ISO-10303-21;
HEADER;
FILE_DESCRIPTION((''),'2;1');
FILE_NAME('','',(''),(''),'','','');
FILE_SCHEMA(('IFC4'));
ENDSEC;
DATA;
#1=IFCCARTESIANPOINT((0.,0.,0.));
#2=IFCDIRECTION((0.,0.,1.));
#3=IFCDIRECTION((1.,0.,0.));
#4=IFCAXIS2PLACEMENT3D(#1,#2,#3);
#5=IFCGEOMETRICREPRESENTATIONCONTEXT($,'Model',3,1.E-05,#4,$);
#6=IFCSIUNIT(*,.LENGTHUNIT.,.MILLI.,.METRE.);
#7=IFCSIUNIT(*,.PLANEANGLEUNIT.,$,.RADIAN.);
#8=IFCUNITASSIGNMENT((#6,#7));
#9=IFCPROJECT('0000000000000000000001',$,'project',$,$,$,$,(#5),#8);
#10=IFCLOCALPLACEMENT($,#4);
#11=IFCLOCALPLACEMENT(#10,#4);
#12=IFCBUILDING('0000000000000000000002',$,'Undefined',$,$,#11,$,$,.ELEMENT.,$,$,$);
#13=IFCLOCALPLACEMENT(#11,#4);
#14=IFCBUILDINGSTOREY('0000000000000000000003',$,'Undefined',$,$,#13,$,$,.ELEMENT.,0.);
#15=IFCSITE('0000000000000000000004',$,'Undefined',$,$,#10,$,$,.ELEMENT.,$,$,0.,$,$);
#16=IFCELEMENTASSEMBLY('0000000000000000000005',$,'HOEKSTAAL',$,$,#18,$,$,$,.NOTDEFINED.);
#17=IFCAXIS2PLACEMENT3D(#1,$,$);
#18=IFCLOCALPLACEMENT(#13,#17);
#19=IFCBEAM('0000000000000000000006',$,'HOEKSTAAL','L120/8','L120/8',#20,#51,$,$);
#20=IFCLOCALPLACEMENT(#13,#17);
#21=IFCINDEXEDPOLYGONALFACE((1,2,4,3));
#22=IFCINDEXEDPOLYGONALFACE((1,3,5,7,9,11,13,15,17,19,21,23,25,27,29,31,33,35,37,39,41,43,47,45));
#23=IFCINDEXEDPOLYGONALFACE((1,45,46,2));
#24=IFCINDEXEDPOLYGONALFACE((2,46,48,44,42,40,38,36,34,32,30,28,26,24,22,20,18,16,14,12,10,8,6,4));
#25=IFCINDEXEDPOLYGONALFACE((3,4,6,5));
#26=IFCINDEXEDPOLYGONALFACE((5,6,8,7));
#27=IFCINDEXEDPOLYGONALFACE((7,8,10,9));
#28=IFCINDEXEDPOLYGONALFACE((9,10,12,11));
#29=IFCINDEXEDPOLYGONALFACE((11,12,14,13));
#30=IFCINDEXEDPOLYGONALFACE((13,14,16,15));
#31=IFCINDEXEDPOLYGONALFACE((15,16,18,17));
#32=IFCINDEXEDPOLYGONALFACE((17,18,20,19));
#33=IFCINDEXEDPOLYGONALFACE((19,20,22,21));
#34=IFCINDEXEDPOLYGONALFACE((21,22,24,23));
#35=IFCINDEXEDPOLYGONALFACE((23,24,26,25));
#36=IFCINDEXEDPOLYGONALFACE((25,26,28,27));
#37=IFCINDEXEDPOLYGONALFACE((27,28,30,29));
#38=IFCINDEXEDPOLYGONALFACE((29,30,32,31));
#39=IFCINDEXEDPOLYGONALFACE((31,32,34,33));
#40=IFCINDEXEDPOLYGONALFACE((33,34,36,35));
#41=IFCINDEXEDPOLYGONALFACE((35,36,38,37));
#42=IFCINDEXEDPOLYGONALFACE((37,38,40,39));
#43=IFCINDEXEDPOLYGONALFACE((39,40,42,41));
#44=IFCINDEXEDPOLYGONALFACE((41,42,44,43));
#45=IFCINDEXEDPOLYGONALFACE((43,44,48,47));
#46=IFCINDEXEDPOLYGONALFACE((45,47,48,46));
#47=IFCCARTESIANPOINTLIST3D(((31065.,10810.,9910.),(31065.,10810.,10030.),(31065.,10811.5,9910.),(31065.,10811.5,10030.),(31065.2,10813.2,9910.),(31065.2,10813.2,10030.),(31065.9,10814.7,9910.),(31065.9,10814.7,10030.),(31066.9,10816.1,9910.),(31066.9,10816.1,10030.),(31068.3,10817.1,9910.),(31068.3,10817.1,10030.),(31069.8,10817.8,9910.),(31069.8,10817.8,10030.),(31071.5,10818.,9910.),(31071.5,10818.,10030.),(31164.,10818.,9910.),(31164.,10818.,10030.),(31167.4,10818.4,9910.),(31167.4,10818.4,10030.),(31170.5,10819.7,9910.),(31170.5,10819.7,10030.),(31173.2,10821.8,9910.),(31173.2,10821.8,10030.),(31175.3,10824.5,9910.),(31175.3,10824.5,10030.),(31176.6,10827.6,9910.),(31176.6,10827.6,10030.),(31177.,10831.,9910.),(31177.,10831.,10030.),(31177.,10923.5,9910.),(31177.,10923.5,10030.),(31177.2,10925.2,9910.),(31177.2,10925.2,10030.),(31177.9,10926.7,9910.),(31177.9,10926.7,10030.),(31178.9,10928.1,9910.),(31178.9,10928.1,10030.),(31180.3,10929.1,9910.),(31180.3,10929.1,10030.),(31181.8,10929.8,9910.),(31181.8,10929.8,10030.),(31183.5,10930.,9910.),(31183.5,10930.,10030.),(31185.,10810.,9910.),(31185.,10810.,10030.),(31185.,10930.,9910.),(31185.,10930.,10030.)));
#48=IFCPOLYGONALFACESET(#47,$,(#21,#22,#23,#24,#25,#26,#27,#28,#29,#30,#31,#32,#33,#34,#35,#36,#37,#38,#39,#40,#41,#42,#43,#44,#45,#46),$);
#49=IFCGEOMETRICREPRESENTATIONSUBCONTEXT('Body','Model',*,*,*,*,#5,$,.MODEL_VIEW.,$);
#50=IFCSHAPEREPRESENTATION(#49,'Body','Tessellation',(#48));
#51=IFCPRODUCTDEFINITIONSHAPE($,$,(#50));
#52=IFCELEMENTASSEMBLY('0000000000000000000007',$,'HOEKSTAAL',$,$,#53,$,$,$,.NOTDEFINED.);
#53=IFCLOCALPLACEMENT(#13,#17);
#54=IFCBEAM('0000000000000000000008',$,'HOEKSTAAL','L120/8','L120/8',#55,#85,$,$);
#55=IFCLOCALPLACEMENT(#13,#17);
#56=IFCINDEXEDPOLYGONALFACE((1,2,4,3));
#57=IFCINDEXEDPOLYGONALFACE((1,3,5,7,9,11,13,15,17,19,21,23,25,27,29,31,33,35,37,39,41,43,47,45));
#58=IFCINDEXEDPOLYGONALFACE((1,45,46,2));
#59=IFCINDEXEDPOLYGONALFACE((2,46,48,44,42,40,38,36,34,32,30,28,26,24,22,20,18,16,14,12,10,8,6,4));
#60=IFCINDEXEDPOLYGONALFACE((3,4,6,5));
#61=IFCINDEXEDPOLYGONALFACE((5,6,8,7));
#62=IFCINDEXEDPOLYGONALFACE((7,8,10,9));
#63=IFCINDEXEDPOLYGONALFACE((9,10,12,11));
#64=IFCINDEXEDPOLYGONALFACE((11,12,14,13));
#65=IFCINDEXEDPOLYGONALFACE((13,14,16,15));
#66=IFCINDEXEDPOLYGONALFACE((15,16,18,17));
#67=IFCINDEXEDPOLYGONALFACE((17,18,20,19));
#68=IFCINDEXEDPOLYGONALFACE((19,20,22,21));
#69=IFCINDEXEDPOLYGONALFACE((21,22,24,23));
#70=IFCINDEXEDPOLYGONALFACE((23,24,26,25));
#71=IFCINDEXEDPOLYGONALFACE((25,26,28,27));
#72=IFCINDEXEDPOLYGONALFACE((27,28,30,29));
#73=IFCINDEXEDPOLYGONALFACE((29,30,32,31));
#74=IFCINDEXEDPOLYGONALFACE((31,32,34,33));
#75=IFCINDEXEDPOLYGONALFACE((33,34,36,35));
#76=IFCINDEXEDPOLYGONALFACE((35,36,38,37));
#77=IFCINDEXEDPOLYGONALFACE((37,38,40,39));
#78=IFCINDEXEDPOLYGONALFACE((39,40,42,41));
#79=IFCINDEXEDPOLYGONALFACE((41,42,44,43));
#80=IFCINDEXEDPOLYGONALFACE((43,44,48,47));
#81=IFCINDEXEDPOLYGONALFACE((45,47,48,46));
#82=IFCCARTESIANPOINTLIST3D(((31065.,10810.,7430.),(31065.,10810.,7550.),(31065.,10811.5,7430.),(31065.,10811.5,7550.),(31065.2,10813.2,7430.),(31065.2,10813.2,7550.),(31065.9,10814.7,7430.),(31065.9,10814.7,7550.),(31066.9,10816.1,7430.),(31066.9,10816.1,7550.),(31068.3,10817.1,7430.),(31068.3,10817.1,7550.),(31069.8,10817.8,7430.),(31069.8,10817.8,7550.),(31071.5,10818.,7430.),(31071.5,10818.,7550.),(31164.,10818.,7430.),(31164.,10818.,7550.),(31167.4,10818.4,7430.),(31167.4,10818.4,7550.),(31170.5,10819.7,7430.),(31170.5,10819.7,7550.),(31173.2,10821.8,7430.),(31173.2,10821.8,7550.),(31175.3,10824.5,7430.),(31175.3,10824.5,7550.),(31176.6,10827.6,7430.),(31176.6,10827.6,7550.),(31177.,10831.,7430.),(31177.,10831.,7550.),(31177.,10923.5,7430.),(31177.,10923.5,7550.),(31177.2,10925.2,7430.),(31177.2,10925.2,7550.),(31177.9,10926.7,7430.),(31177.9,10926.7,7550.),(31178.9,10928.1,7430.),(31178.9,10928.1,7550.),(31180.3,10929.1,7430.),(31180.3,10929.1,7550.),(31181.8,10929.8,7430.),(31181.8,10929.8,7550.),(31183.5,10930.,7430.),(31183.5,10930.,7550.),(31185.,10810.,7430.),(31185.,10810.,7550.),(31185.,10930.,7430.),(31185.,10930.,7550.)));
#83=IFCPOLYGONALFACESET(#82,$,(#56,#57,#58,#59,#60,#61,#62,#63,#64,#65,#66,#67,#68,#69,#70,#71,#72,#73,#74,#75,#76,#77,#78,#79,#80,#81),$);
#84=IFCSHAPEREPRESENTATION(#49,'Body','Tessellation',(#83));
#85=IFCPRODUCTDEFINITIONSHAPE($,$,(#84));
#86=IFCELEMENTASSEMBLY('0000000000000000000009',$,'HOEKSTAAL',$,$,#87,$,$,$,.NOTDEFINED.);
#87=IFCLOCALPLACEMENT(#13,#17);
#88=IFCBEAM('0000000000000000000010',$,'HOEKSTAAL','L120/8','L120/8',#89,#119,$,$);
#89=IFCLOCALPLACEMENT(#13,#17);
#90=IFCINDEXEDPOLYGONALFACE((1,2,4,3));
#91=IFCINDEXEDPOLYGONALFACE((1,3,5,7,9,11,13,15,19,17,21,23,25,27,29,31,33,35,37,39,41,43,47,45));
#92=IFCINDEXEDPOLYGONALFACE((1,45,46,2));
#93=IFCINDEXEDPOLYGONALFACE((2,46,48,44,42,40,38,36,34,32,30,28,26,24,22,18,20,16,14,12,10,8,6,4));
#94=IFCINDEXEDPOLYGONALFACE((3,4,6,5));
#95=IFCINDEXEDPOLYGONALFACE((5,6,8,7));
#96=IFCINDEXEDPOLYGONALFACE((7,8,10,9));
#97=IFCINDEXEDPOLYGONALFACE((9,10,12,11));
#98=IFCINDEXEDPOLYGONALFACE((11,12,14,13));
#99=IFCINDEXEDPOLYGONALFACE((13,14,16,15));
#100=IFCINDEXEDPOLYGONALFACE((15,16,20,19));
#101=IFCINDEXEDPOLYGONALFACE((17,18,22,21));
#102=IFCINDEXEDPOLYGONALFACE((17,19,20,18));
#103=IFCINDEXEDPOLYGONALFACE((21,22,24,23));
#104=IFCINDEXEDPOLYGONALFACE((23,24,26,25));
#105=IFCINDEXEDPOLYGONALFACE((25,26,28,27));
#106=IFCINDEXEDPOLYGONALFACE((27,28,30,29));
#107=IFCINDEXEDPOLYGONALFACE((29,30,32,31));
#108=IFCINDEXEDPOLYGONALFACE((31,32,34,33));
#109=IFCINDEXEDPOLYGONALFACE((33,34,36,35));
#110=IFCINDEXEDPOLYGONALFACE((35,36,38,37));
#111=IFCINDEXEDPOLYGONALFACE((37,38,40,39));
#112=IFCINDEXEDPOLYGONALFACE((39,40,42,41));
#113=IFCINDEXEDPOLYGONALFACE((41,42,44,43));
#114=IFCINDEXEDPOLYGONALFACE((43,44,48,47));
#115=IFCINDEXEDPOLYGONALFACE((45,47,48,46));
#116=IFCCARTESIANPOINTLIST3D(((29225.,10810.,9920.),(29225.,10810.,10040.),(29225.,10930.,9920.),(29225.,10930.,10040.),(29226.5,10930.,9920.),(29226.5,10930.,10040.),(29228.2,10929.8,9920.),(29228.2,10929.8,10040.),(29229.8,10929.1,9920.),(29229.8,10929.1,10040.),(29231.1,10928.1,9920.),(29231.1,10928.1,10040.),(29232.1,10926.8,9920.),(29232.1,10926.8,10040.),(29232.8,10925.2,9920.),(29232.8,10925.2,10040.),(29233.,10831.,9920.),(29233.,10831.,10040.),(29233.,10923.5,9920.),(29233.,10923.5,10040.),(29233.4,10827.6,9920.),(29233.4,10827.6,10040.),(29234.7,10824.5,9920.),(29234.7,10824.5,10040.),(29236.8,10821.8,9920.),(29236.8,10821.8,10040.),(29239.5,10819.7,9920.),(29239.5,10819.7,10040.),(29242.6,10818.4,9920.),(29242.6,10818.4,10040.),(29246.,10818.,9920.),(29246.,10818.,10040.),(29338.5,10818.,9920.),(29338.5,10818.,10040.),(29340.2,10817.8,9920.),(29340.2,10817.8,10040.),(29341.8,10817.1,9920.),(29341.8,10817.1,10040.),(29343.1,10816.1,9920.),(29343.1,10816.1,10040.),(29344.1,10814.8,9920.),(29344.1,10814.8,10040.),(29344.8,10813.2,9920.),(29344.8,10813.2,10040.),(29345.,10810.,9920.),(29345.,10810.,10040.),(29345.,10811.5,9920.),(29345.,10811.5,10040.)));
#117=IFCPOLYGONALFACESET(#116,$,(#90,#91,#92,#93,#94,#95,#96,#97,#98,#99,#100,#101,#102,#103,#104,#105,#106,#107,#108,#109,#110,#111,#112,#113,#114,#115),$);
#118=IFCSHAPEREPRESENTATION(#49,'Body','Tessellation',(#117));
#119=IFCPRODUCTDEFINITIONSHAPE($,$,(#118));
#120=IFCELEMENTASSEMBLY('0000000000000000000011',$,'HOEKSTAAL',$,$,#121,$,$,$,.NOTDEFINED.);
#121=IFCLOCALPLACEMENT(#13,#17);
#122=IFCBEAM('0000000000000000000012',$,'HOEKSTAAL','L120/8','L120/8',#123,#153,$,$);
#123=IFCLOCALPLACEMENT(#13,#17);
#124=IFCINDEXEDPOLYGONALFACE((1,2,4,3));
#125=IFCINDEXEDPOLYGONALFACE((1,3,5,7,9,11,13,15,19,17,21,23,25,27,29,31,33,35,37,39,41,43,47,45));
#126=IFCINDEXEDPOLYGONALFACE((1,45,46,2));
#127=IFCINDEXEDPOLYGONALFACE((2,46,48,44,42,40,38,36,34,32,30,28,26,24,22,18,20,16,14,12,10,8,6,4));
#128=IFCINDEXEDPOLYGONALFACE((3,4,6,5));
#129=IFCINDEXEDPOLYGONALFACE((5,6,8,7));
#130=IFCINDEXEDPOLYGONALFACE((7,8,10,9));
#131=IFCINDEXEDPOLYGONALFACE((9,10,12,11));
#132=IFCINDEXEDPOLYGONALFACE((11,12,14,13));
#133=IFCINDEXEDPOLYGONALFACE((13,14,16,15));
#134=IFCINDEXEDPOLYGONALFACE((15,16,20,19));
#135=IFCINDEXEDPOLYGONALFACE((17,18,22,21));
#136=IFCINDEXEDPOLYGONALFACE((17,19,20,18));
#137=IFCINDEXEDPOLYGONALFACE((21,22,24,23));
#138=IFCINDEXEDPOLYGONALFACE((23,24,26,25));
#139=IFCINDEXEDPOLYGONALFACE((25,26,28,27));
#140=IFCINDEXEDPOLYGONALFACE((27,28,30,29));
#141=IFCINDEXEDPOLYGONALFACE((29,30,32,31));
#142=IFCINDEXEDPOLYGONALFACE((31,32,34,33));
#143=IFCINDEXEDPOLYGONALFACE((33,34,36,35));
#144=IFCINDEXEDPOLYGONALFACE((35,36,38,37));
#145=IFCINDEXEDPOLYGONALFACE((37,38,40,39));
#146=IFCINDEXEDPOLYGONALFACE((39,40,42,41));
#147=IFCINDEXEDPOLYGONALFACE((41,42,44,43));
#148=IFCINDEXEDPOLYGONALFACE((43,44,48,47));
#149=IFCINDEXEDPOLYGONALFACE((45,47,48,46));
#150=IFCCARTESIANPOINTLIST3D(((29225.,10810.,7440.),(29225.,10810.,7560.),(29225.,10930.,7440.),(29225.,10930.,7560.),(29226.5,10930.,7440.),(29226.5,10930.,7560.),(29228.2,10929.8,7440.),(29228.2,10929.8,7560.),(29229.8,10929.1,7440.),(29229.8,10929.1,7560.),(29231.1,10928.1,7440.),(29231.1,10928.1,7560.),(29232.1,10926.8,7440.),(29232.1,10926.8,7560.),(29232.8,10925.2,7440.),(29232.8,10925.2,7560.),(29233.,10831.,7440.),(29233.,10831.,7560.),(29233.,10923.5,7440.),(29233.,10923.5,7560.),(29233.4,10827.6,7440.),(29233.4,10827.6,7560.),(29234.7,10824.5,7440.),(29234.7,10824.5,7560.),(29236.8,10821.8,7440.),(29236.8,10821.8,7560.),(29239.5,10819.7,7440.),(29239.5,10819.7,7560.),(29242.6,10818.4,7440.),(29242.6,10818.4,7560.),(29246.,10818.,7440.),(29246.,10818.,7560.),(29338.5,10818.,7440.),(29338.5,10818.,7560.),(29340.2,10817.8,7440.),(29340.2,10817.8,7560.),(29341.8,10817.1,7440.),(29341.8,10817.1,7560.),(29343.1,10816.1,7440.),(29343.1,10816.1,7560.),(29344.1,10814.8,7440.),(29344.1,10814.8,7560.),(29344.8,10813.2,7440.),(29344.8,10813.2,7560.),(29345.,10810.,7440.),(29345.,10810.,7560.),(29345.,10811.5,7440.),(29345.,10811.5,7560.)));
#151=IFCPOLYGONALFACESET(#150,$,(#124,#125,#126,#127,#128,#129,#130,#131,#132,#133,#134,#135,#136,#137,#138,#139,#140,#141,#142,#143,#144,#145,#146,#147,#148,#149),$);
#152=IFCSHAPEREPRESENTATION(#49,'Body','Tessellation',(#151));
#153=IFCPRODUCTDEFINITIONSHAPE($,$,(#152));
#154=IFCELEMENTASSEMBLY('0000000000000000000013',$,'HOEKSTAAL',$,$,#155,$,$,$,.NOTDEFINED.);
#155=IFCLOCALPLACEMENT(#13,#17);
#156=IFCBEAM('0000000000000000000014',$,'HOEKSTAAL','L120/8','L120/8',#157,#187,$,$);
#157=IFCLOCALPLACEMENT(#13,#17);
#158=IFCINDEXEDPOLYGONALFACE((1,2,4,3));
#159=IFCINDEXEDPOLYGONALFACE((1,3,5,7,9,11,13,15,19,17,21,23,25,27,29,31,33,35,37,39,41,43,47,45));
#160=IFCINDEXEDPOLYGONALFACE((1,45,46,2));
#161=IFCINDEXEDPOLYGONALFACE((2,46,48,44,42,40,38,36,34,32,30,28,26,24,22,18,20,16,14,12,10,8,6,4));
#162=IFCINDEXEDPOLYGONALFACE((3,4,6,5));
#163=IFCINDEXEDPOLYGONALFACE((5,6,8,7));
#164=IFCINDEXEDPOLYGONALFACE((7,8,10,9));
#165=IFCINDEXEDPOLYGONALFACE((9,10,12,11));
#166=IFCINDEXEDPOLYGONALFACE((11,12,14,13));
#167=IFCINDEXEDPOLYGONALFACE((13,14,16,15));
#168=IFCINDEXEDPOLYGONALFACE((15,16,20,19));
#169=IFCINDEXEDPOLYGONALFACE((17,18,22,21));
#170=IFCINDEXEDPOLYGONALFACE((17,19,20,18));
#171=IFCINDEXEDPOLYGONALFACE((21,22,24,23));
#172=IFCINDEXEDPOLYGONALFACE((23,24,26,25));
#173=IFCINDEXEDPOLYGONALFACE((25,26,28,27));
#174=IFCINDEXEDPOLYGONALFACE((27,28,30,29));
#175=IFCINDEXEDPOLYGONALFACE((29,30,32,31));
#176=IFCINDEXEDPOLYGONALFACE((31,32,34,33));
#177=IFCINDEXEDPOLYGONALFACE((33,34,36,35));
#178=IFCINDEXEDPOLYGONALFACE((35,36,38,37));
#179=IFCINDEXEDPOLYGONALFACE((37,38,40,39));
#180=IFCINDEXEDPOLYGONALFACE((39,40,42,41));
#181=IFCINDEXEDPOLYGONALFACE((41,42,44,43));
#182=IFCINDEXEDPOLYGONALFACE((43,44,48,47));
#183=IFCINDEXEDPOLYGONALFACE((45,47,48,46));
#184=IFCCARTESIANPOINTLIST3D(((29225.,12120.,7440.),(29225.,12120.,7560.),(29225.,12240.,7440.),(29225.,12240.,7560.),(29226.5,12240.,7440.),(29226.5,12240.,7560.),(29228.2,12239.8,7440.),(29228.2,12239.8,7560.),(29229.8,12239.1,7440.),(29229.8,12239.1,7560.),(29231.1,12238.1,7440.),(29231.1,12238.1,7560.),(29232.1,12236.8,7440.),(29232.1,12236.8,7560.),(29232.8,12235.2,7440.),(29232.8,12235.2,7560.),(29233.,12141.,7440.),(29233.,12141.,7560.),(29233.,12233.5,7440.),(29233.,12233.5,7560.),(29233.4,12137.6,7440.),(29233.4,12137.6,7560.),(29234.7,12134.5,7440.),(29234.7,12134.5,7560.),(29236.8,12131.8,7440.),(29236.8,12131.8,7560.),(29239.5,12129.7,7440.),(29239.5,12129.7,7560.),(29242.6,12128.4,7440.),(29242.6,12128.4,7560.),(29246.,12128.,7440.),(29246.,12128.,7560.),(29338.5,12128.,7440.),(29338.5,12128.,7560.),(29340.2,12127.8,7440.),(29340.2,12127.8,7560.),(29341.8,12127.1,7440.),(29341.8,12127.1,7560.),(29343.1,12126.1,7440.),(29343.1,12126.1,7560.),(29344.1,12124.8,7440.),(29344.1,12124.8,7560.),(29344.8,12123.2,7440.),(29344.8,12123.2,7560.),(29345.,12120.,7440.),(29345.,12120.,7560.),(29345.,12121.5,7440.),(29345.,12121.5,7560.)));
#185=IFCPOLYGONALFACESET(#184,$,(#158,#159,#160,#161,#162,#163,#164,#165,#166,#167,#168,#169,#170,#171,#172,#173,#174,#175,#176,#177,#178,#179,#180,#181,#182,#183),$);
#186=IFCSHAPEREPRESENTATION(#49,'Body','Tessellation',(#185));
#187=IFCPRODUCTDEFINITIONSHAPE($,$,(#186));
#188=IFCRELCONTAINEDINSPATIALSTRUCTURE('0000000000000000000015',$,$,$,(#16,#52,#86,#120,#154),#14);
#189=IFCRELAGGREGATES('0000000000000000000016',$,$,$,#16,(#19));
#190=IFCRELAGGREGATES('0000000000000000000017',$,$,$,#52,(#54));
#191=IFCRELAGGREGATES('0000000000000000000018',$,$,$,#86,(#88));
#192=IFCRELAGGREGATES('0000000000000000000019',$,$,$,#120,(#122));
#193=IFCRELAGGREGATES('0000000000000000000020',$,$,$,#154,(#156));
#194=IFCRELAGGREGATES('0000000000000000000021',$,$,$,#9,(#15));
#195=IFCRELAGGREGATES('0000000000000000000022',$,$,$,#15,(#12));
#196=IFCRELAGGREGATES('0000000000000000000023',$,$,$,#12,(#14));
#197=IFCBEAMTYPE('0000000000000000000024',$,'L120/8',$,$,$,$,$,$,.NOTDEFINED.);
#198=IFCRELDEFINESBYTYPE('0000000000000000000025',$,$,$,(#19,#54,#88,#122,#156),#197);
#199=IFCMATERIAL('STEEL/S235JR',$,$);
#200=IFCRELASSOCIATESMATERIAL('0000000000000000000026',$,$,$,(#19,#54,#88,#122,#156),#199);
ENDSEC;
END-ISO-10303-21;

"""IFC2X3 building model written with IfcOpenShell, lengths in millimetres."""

from ifc_helpers import new_model, si_unit, frame, origin_with_axes, origin_2d_with_axis, place, context, subcontext, project, spatial, l_section, extrude, material, type_object, element, aggregate, save


model = new_model("IFC2X3")

# Units and contexts
model_context = context("Model", 3, precision=1e-05, world=origin_with_axes())
body_context = subcontext(model_context, "Body", "Model", "MODEL_VIEW")
ifc_project = project(units=[si_unit("LENGTHUNIT", "METRE", prefix="MILLI"), si_unit("PLANEANGLEUNIT", "RADIAN")], contexts=[model_context])

# Site, building, storey
site_placement = place(None, origin_with_axes())
site = spatial("IfcSite", under=ifc_project, at=site_placement, Name="Undefined", CompositionType="ELEMENT", RefElevation=0.0)
building_placement = place(site_placement, origin_with_axes())
building = spatial("IfcBuilding", under=site, at=building_placement, Name="Undefined", CompositionType="ELEMENT")
storey_placement = place(building_placement, origin_with_axes())
storey = spatial("IfcBuildingStorey", under=building, at=storey_placement, Name="Undefined", CompositionType="ELEMENT", Elevation=0.0)

# Element assemblies, beams
assembly_1_placement = place(storey_placement, origin_with_axes())
assembly_1 = element("IfcElementAssembly", 1, at=assembly_1_placement, inside=storey, Name="HOEKSTAAL", PredefinedType="NOTDEFINED")
ifc_material_1 = material(Name="STEEL/S235JR")
beam_type_1 = type_object("IfcBeamType", Name="L120/8", PredefinedType="NOTDEFINED")
beam_1_placement = place(assembly_1_placement, frame((31125.0, 10870.0, 10030.0), z_axis=(-1.0, 0.0, 0.0), x_axis=(0.0, 0.0, -1.0)))
beam_1 = element("IfcBeam", 2, at=beam_1_placement, type_object=beam_type_1, material=ifc_material_1, Name="HOEKSTAAL", Description="L120/8", ObjectType="L120/8", context=body_context, shape_type="SweptSolid", body=[
    extrude(l_section(Depth=120.0, Width=120.0, Thickness=8.0, FilletRadius=13.0, EdgeRadius=6.5, at=origin_2d_with_axis()), frame((120.0, 0.0, 0.0), z_axis=(-1.0, 0.0, 0.0), x_axis=(0.0, -1.0, 0.0)), (0.0, 0.0, 1.0), 120.0),
])
aggregate(assembly_1, [beam_1])
assembly_2_placement = place(storey_placement, origin_with_axes())
assembly_2 = element("IfcElementAssembly", 3, at=assembly_2_placement, inside=storey, Name="HOEKSTAAL", PredefinedType="NOTDEFINED")
beam_2_placement = place(assembly_2_placement, frame((31125.0, 10870.0, 7550.0), z_axis=(-1.0, 0.0, 0.0), x_axis=(0.0, 0.0, -1.0)))
beam_2 = element("IfcBeam", 4, at=beam_2_placement, type_object=beam_type_1, material=ifc_material_1, Name="HOEKSTAAL", Description="L120/8", ObjectType="L120/8", context=body_context, shape_type="SweptSolid", body=[
    extrude(l_section(Depth=120.0, Width=120.0, Thickness=8.0, FilletRadius=13.0, EdgeRadius=6.5, at=origin_2d_with_axis()), frame((120.0, 0.0, 0.0), z_axis=(-1.0, 0.0, 0.0), x_axis=(0.0, -1.0, 0.0)), (0.0, 0.0, 1.0), 120.0),
])
aggregate(assembly_2, [beam_2])
assembly_3_placement = place(storey_placement, origin_with_axes())
assembly_3 = element("IfcElementAssembly", 5, at=assembly_3_placement, inside=storey, Name="HOEKSTAAL", PredefinedType="NOTDEFINED")
beam_3_placement = place(assembly_3_placement, frame((29285.0, 10870.0, 9920.0), z_axis=(1.0, 0.0, 0.0), x_axis=(0.0, 0.0, 1.0)))
beam_3 = element("IfcBeam", 6, at=beam_3_placement, type_object=beam_type_1, material=ifc_material_1, Name="HOEKSTAAL", Description="L120/8", ObjectType="L120/8", context=body_context, shape_type="SweptSolid", body=[
    extrude(l_section(Depth=120.0, Width=120.0, Thickness=8.0, FilletRadius=13.0, EdgeRadius=6.5, at=origin_2d_with_axis()), frame((120.0, 0.0, 0.0), z_axis=(-1.0, 0.0, 0.0), x_axis=(0.0, -1.0, 0.0)), (0.0, 0.0, 1.0), 120.0),
])
aggregate(assembly_3, [beam_3])
assembly_4_placement = place(storey_placement, origin_with_axes())
assembly_4 = element("IfcElementAssembly", 7, at=assembly_4_placement, inside=storey, Name="HOEKSTAAL", PredefinedType="NOTDEFINED")
beam_4_placement = place(assembly_4_placement, frame((29285.0, 10870.0, 7440.0), z_axis=(1.0, 0.0, 0.0), x_axis=(0.0, 0.0, 1.0)))
beam_4 = element("IfcBeam", 8, at=beam_4_placement, type_object=beam_type_1, material=ifc_material_1, Name="HOEKSTAAL", Description="L120/8", ObjectType="L120/8", context=body_context, shape_type="SweptSolid", body=[
    extrude(l_section(Depth=120.0, Width=120.0, Thickness=8.0, FilletRadius=13.0, EdgeRadius=6.5, at=origin_2d_with_axis()), frame((120.0, 0.0, 0.0), z_axis=(-1.0, 0.0, 0.0), x_axis=(0.0, -1.0, 0.0)), (0.0, 0.0, 1.0), 120.0),
])
aggregate(assembly_4, [beam_4])
assembly_5_placement = place(storey_placement, origin_with_axes())
assembly_5 = element("IfcElementAssembly", 9, at=assembly_5_placement, inside=storey, Name="HOEKSTAAL", PredefinedType="NOTDEFINED")
beam_5_placement = place(assembly_5_placement, frame((29285.0, 12180.0, 7440.0), z_axis=(1.0, 0.0, 0.0), x_axis=(0.0, 0.0, 1.0)))
beam_5 = element("IfcBeam", 10, at=beam_5_placement, type_object=beam_type_1, material=ifc_material_1, Name="HOEKSTAAL", Description="L120/8", ObjectType="L120/8", context=body_context, shape_type="SweptSolid", body=[
    extrude(l_section(Depth=120.0, Width=120.0, Thickness=8.0, FilletRadius=13.0, EdgeRadius=6.5, at=origin_2d_with_axis()), frame((120.0, 0.0, 0.0), z_axis=(-1.0, 0.0, 0.0), x_axis=(0.0, -1.0, 0.0)), (0.0, 0.0, 1.0), 120.0),
])
aggregate(assembly_5, [beam_5])

save(model, "model.ifc")
